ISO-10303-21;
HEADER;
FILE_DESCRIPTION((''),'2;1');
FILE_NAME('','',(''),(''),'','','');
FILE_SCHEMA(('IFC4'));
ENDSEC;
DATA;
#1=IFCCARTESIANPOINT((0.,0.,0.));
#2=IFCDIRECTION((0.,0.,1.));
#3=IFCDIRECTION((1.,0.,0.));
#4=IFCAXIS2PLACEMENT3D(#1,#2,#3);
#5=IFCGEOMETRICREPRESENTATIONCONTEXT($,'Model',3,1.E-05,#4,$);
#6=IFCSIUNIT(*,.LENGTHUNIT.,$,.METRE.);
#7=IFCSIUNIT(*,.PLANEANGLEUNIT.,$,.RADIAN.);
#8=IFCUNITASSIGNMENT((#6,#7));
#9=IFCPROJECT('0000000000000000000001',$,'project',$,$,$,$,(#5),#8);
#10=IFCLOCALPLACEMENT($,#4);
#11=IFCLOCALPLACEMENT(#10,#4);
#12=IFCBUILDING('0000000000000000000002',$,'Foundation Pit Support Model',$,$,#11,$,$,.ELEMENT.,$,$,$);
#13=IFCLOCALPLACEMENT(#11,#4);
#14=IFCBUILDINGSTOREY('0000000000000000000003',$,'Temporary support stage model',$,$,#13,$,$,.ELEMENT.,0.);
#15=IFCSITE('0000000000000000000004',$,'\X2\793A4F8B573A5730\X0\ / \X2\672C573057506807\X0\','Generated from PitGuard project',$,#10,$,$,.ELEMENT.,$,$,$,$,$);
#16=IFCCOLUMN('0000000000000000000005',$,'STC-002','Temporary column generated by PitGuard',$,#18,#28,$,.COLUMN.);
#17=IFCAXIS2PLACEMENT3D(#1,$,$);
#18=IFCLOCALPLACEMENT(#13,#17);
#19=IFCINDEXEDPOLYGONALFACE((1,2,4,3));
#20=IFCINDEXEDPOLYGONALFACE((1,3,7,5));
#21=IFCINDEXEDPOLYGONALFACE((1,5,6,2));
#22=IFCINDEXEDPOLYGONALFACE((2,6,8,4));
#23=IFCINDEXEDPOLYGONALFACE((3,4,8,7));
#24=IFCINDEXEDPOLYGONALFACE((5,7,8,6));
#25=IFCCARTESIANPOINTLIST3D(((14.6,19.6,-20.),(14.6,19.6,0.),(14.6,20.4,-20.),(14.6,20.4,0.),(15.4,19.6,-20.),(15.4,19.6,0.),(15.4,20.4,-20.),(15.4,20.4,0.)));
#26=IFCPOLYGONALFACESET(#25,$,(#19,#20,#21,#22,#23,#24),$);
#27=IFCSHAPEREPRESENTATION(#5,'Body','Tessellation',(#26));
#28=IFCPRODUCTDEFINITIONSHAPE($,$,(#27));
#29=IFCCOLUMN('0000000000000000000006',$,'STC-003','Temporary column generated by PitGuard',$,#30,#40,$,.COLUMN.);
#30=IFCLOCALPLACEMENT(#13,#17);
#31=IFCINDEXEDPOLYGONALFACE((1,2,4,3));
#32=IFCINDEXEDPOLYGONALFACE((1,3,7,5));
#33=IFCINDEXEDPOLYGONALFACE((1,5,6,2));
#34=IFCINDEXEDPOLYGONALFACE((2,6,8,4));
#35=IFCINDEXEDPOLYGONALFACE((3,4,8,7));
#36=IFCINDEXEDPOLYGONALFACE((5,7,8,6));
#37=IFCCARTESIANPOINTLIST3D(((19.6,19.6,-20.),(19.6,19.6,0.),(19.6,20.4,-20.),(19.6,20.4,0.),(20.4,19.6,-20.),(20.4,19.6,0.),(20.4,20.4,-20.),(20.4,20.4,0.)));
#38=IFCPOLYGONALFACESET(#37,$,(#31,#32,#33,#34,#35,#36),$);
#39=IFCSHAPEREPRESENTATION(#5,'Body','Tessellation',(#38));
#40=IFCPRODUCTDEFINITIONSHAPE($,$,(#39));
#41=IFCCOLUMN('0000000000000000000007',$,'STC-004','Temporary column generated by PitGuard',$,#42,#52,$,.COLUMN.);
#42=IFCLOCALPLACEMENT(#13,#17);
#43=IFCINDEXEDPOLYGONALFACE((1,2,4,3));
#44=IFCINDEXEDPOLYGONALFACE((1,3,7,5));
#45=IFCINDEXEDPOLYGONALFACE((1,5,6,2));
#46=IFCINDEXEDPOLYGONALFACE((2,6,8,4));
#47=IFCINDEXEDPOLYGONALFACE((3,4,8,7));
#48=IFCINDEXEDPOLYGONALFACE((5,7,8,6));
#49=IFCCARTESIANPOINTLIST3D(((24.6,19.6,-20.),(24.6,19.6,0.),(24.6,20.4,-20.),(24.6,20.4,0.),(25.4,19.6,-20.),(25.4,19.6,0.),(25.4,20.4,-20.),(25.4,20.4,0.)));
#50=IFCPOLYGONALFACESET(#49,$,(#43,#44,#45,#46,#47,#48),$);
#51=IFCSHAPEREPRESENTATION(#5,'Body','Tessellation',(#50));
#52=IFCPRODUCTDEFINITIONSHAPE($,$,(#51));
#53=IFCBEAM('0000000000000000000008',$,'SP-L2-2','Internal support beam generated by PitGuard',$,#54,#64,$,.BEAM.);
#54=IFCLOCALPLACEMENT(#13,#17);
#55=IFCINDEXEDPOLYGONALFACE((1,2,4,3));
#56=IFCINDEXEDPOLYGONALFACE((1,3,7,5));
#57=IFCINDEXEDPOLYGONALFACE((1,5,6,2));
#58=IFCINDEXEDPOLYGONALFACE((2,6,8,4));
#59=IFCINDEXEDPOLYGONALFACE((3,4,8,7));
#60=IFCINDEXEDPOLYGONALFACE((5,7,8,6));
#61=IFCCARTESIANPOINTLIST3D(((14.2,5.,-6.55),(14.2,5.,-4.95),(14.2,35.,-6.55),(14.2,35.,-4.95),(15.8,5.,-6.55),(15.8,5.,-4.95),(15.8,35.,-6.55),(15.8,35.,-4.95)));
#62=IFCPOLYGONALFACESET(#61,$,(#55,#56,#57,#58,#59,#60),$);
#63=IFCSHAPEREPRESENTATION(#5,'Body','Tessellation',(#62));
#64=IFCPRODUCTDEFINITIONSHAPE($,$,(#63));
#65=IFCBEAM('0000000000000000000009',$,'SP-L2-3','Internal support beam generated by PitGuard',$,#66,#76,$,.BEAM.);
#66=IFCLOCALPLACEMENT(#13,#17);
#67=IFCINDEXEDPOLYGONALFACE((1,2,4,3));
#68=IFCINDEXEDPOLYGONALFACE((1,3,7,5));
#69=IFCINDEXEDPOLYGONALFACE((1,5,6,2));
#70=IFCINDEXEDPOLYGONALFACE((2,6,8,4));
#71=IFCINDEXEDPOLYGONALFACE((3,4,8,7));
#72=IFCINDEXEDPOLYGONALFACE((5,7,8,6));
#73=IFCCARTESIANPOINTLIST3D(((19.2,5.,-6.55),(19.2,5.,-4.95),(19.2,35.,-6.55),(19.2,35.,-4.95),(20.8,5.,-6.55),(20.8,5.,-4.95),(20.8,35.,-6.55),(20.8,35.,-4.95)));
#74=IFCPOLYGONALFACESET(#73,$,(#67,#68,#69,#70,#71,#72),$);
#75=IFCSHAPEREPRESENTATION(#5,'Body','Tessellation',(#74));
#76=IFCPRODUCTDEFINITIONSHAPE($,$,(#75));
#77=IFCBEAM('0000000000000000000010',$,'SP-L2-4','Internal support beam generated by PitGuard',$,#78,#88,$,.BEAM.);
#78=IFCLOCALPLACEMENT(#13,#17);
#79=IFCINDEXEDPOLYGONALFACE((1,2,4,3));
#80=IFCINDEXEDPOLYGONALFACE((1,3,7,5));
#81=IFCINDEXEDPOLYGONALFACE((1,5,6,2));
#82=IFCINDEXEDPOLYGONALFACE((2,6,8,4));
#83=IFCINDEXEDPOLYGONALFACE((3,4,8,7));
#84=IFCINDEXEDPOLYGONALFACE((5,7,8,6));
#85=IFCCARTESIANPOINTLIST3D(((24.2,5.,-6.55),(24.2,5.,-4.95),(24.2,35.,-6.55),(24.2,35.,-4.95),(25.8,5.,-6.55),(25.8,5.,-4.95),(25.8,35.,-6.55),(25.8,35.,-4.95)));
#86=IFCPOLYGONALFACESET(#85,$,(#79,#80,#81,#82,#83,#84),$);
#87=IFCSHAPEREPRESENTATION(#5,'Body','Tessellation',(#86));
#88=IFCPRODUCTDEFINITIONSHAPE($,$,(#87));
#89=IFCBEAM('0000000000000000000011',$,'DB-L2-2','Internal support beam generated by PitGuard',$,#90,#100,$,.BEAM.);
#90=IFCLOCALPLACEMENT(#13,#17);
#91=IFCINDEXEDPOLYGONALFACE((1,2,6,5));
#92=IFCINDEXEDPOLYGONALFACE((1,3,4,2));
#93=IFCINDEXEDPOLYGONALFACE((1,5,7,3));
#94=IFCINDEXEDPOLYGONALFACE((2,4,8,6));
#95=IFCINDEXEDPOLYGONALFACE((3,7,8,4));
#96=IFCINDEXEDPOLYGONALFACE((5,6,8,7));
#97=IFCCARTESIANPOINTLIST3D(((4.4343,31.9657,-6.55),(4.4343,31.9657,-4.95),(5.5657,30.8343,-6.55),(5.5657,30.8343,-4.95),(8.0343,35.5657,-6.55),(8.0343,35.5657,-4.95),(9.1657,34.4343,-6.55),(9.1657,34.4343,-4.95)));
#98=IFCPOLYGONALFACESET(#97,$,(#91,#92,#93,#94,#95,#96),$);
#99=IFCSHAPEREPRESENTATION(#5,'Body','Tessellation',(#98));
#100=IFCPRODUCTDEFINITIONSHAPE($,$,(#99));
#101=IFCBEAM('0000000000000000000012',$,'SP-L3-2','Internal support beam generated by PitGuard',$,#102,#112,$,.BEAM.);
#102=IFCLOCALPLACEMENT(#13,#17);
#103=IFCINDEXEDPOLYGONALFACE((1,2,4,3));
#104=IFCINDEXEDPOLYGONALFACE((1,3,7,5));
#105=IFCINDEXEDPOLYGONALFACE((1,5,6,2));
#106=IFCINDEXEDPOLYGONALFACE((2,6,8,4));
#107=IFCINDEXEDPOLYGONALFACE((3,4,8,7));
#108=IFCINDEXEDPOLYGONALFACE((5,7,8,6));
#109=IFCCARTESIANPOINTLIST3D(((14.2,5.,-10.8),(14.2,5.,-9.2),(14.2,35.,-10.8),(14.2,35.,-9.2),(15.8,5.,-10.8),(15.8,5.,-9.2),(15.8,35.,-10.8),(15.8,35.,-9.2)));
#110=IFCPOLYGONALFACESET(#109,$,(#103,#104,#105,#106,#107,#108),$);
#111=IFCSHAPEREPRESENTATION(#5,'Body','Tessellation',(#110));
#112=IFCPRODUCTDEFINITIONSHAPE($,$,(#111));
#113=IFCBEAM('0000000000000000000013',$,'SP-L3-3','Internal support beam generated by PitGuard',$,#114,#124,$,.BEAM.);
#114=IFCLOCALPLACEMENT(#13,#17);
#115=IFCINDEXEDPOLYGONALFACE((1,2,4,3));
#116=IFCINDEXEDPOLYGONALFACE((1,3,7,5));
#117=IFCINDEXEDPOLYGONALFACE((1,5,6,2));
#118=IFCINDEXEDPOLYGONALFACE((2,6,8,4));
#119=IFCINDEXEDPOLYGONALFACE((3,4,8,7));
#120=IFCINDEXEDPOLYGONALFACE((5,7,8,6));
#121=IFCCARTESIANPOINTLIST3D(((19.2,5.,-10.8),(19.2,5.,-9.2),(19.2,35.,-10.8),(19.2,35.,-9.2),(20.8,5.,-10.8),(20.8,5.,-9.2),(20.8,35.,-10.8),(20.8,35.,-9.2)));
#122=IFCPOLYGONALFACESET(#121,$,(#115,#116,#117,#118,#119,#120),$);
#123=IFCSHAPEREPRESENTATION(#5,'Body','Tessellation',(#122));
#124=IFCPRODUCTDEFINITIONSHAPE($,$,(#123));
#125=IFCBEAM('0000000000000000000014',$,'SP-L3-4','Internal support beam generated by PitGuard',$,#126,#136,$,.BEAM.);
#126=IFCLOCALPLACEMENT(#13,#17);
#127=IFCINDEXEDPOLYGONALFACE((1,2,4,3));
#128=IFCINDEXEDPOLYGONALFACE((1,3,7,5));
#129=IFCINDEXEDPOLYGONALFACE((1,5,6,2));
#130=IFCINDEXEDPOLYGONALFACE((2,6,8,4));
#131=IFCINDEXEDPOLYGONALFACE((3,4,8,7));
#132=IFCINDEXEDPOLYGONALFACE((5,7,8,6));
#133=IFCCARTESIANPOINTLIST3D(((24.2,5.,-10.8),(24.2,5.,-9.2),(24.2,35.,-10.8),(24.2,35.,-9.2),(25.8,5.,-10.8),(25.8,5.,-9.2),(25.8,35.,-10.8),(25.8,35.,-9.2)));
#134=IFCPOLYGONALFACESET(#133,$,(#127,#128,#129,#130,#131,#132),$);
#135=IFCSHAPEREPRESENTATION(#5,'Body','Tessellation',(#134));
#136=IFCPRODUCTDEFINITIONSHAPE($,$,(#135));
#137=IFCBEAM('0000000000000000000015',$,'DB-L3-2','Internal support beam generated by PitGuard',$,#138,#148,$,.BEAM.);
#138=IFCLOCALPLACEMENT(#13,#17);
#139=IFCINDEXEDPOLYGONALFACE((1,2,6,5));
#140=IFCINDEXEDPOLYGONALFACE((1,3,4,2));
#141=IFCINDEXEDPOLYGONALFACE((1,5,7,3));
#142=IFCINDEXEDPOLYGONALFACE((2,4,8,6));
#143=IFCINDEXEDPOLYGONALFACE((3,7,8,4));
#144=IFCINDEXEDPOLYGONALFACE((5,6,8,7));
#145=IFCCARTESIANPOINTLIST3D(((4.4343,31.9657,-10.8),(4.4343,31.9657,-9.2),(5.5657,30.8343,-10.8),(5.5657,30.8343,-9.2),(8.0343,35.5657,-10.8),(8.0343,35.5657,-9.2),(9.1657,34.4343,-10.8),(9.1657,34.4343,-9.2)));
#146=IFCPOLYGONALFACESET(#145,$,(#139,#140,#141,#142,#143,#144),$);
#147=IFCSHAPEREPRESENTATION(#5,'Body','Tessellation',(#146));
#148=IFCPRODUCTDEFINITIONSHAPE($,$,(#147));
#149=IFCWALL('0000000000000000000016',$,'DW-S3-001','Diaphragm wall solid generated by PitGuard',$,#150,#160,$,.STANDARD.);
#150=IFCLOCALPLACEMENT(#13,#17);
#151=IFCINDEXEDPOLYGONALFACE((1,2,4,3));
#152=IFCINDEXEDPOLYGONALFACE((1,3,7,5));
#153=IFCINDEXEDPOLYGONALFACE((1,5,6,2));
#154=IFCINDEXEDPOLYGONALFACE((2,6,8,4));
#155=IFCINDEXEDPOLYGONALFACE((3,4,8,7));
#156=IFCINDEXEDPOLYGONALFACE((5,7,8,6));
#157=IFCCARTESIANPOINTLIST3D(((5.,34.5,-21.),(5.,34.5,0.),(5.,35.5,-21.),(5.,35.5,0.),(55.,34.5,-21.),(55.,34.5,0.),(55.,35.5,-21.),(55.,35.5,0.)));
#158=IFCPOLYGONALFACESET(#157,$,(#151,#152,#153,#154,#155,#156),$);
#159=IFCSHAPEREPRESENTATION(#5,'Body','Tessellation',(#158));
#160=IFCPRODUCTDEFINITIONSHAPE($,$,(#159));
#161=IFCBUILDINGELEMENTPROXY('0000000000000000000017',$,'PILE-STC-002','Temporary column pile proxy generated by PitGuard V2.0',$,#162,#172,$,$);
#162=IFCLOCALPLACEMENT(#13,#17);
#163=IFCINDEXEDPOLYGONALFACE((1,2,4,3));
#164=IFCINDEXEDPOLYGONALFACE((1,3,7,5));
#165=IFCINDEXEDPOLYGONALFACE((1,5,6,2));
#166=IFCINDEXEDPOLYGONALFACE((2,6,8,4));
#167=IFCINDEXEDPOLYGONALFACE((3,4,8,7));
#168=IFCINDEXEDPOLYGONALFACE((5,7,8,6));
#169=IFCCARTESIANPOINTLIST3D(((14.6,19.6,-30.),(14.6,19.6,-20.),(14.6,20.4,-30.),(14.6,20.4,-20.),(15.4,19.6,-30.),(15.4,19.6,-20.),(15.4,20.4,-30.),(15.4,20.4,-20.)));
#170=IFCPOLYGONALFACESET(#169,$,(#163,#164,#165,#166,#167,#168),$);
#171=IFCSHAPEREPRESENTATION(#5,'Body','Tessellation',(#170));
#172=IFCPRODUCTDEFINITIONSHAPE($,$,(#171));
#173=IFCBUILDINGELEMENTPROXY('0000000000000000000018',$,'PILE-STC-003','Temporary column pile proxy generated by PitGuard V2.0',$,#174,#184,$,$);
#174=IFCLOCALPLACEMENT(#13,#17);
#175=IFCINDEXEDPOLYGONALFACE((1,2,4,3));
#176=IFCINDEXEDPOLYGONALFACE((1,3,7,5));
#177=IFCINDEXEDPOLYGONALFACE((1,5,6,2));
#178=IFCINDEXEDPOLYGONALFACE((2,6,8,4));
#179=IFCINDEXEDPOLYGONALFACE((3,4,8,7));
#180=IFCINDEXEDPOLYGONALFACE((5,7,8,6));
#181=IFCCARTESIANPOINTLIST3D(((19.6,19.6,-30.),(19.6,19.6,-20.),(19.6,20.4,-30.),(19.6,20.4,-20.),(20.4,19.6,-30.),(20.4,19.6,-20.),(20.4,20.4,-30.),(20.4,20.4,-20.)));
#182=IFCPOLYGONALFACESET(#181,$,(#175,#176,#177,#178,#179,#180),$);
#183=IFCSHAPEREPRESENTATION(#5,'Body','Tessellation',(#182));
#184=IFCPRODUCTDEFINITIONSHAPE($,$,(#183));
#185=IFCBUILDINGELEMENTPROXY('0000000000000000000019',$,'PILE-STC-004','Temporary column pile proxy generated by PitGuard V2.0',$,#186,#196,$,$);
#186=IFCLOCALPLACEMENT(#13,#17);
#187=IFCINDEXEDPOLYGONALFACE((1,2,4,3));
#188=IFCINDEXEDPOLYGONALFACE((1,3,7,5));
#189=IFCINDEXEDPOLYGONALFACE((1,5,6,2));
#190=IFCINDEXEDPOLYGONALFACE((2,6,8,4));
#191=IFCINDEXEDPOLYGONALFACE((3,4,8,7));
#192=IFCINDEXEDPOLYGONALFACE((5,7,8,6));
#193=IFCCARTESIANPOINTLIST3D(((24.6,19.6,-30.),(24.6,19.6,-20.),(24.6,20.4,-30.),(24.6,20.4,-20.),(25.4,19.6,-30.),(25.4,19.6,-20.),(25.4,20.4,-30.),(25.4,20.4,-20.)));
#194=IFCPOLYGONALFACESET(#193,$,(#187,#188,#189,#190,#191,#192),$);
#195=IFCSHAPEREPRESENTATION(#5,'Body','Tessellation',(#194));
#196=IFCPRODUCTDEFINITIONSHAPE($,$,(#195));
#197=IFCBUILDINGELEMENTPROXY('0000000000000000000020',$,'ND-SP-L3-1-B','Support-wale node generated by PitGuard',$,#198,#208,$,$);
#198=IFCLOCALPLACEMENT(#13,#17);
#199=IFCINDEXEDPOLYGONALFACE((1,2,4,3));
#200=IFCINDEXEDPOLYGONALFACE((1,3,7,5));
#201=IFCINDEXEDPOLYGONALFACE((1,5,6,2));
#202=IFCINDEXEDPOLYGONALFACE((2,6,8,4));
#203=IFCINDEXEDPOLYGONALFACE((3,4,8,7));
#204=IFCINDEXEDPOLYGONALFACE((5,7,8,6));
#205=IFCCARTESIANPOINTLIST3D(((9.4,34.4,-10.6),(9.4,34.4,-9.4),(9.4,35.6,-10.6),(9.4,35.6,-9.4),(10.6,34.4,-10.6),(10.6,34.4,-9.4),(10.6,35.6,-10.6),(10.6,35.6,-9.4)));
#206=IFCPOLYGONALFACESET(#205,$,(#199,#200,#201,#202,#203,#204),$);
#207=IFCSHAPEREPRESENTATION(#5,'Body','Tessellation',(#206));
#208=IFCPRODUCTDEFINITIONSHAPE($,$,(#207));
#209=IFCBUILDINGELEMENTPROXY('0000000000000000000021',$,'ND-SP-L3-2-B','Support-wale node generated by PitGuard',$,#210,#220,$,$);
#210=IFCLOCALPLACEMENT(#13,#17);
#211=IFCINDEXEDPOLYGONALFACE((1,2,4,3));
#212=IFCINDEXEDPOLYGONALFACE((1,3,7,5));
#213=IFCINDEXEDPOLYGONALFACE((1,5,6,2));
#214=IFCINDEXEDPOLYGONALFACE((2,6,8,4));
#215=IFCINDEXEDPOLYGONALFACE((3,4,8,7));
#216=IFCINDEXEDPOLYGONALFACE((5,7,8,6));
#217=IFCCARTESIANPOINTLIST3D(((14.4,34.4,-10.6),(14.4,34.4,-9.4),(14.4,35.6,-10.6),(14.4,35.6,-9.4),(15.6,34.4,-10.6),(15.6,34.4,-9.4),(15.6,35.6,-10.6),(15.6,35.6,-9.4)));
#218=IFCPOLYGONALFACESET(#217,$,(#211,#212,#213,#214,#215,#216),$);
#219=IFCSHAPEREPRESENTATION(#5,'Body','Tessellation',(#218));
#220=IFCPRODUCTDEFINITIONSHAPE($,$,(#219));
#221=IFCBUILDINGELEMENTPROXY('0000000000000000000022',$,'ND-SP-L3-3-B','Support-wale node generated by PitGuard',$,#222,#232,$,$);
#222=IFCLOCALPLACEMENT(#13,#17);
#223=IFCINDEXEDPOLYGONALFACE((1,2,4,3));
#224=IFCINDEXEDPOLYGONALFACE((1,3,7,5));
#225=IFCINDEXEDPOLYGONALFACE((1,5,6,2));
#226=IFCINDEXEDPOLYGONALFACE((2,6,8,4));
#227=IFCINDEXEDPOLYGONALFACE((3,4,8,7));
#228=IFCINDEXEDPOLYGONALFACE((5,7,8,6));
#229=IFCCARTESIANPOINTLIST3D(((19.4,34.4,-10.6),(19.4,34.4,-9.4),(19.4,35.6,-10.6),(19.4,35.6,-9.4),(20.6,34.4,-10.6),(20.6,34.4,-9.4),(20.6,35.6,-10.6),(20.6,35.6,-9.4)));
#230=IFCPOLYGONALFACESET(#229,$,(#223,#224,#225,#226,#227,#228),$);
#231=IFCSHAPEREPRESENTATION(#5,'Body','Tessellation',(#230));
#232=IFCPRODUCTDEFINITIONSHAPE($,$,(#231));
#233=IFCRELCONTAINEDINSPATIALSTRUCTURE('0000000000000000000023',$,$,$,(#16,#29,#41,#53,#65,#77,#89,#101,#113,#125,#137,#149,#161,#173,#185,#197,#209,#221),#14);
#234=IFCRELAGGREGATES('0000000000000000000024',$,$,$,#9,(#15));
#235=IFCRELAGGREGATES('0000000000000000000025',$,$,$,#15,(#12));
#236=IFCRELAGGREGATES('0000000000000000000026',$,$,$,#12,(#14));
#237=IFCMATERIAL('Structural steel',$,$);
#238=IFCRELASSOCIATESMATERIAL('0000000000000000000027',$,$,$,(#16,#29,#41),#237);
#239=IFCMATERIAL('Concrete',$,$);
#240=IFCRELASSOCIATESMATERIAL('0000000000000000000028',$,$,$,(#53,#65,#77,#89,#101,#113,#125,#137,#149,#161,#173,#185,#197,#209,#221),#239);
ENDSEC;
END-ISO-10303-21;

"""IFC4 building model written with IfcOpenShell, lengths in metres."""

from ifc_helpers import new_model, si_unit, frame, origin_with_axes, origin_2d, place, context, project, spatial, rectangle, extrude, material, element, save


model = new_model("IFC4")

# Units and contexts
model_context = context("Model", 3, precision=1e-05, world=origin_with_axes())
ifc_project = project(units=[si_unit("LENGTHUNIT", "METRE"), si_unit("PLANEANGLEUNIT", "RADIAN")], contexts=[model_context])

# Site, building, storey
site_placement = place(None, origin_with_axes())
site = spatial("IfcSite", under=ifc_project, at=site_placement, Name="示例场地 / 本地坐标", Description="Generated from PitGuard project", CompositionType="ELEMENT")
building_placement = place(site_placement, origin_with_axes())
building = spatial("IfcBuilding", under=site, at=building_placement, Name="Foundation Pit Support Model", CompositionType="ELEMENT")
storey_placement = place(building_placement, origin_with_axes())
storey = spatial("IfcBuildingStorey", under=building, at=storey_placement, Name="Temporary support stage model", CompositionType="ELEMENT", Elevation=0.0)

# Columns
ifc_material_1 = material(Name="Structural steel")
for number, where, z_axis, x_axis, name in (
    (1, (15.0, 20.0, -20.0), (0.0, 0.0, 1.0), (1.0, 0.0, 0.0), "STC-002"),
    (2, (20.0, 20.0, -20.0), (0.0, 0.0, 1.0), (1.0, 0.0, 0.0), "STC-003"),
    (3, (25.0, 20.0, -20.0), (0.0, 0.0, 1.0), (1.0, 0.0, 0.0), "STC-004"),
):
    element("IfcColumn", number, at=place(storey_placement, frame(where, z_axis=z_axis, x_axis=x_axis)), inside=storey, material=ifc_material_1, Name=name, Description="Temporary column generated by PitGuard", PredefinedType="COLUMN", context=model_context, shape_type="SweptSolid", body=[
        extrude(rectangle(XDim=0.8, YDim=0.8, at=origin_2d()), origin_with_axes(), (0.0, 0.0, 1.0), 20.0),
    ])

# Beams
ifc_material_2 = material(Name="Concrete")
for number, where, z_axis, x_axis, name in (
    (4, (15.0, 20.0, -6.55), (0.0, 0.0, 1.0), (0.0, 1.0, 0.0), "SP-L2-2"),
    (5, (20.0, 20.0, -6.55), (0.0, 0.0, 1.0), (0.0, 1.0, 0.0), "SP-L2-3"),
    (6, (25.0, 20.0, -6.55), (0.0, 0.0, 1.0), (0.0, 1.0, 0.0), "SP-L2-4"),
):
    element("IfcBeam", number, at=place(storey_placement, frame(where, z_axis=z_axis, x_axis=x_axis)), inside=storey, material=ifc_material_2, Name=name, Description="Internal support beam generated by PitGuard", PredefinedType="BEAM", context=model_context, shape_type="SweptSolid", body=[
        extrude(rectangle(XDim=30.0, YDim=1.6, at=origin_2d()), origin_with_axes(), (0.0, 0.0, 1.0), 1.6),
    ])
beam_1_placement = place(storey_placement, frame((6.8, 33.2, -6.55), z_axis=(0.0, 0.0, 1.0), x_axis=(-0.707107, -0.707107, 0.0)))
element("IfcBeam", 7, at=beam_1_placement, inside=storey, material=ifc_material_2, Name="DB-L2-2", Description="Internal support beam generated by PitGuard", PredefinedType="BEAM", context=model_context, shape_type="SweptSolid", body=[
    extrude(rectangle(XDim=5.0912, YDim=1.6, at=origin_2d()), origin_with_axes(), (0.0, 0.0, 1.0), 1.6),
])
for number, where, z_axis, x_axis, name in (
    (8, (15.0, 20.0, -10.8), (0.0, 0.0, 1.0), (0.0, 1.0, 0.0), "SP-L3-2"),
    (9, (20.0, 20.0, -10.8), (0.0, 0.0, 1.0), (0.0, 1.0, 0.0), "SP-L3-3"),
    (10, (25.0, 20.0, -10.8), (0.0, 0.0, 1.0), (0.0, 1.0, 0.0), "SP-L3-4"),
):
    element("IfcBeam", number, at=place(storey_placement, frame(where, z_axis=z_axis, x_axis=x_axis)), inside=storey, material=ifc_material_2, Name=name, Description="Internal support beam generated by PitGuard", PredefinedType="BEAM", context=model_context, shape_type="SweptSolid", body=[
        extrude(rectangle(XDim=30.0, YDim=1.6, at=origin_2d()), origin_with_axes(), (0.0, 0.0, 1.0), 1.6),
    ])
beam_2_placement = place(storey_placement, frame((6.8, 33.2, -10.8), z_axis=(0.0, 0.0, 1.0), x_axis=(-0.707107, -0.707107, 0.0)))
element("IfcBeam", 11, at=beam_2_placement, inside=storey, material=ifc_material_2, Name="DB-L3-2", Description="Internal support beam generated by PitGuard", PredefinedType="BEAM", context=model_context, shape_type="SweptSolid", body=[
    extrude(rectangle(XDim=5.0912, YDim=1.6, at=origin_2d()), origin_with_axes(), (0.0, 0.0, 1.0), 1.6),
])

# Wall
wall_placement = place(storey_placement, frame((30.0, 35.0, -21.0), z_axis=(0.0, 0.0, 1.0), x_axis=(-1.0, 0.0, 0.0)))
element("IfcWall", 12, at=wall_placement, inside=storey, material=ifc_material_2, Name="DW-S3-001", Description="Diaphragm wall solid generated by PitGuard", PredefinedType="STANDARD", context=model_context, shape_type="SweptSolid", body=[
    extrude(rectangle(XDim=50.0, YDim=1.0, at=origin_2d()), origin_with_axes(), (0.0, 0.0, 1.0), 21.0),
])

# Building element proxies
for number, where, z_axis, x_axis, name in (
    (13, (15.0, 20.0, -30.0), (0.0, 0.0, 1.0), (1.0, 0.0, 0.0), "PILE-STC-002"),
    (14, (20.0, 20.0, -30.0), (0.0, 0.0, 1.0), (1.0, 0.0, 0.0), "PILE-STC-003"),
    (15, (25.0, 20.0, -30.0), (0.0, 0.0, 1.0), (1.0, 0.0, 0.0), "PILE-STC-004"),
):
    element("IfcBuildingElementProxy", number, at=place(storey_placement, frame(where, z_axis=z_axis, x_axis=x_axis)), inside=storey, material=ifc_material_2, Name=name, Description="Temporary column pile proxy generated by PitGuard V2.0", context=model_context, shape_type="SweptSolid", body=[
        extrude(rectangle(XDim=0.8, YDim=0.8, at=origin_2d()), origin_with_axes(), (0.0, 0.0, 1.0), 10.0),
    ])
for number, where, z_axis, x_axis, name in (
    (16, (10.0, 35.0, -10.6), (0.0, 0.0, 1.0), (1.0, 0.0, 0.0), "ND-SP-L3-1-B"),
    (17, (15.0, 35.0, -10.6), (0.0, 0.0, 1.0), (1.0, 0.0, 0.0), "ND-SP-L3-2-B"),
    (18, (20.0, 35.0, -10.6), (0.0, 0.0, 1.0), (1.0, 0.0, 0.0), "ND-SP-L3-3-B"),
):
    element("IfcBuildingElementProxy", number, at=place(storey_placement, frame(where, z_axis=z_axis, x_axis=x_axis)), inside=storey, material=ifc_material_2, Name=name, Description="Support-wale node generated by PitGuard", context=model_context, shape_type="SweptSolid", body=[
        extrude(rectangle(XDim=1.2, YDim=1.2, at=origin_2d()), origin_with_axes(), (0.0, 0.0, 1.0), 1.2),
    ])

save(model, "model.ifc")
